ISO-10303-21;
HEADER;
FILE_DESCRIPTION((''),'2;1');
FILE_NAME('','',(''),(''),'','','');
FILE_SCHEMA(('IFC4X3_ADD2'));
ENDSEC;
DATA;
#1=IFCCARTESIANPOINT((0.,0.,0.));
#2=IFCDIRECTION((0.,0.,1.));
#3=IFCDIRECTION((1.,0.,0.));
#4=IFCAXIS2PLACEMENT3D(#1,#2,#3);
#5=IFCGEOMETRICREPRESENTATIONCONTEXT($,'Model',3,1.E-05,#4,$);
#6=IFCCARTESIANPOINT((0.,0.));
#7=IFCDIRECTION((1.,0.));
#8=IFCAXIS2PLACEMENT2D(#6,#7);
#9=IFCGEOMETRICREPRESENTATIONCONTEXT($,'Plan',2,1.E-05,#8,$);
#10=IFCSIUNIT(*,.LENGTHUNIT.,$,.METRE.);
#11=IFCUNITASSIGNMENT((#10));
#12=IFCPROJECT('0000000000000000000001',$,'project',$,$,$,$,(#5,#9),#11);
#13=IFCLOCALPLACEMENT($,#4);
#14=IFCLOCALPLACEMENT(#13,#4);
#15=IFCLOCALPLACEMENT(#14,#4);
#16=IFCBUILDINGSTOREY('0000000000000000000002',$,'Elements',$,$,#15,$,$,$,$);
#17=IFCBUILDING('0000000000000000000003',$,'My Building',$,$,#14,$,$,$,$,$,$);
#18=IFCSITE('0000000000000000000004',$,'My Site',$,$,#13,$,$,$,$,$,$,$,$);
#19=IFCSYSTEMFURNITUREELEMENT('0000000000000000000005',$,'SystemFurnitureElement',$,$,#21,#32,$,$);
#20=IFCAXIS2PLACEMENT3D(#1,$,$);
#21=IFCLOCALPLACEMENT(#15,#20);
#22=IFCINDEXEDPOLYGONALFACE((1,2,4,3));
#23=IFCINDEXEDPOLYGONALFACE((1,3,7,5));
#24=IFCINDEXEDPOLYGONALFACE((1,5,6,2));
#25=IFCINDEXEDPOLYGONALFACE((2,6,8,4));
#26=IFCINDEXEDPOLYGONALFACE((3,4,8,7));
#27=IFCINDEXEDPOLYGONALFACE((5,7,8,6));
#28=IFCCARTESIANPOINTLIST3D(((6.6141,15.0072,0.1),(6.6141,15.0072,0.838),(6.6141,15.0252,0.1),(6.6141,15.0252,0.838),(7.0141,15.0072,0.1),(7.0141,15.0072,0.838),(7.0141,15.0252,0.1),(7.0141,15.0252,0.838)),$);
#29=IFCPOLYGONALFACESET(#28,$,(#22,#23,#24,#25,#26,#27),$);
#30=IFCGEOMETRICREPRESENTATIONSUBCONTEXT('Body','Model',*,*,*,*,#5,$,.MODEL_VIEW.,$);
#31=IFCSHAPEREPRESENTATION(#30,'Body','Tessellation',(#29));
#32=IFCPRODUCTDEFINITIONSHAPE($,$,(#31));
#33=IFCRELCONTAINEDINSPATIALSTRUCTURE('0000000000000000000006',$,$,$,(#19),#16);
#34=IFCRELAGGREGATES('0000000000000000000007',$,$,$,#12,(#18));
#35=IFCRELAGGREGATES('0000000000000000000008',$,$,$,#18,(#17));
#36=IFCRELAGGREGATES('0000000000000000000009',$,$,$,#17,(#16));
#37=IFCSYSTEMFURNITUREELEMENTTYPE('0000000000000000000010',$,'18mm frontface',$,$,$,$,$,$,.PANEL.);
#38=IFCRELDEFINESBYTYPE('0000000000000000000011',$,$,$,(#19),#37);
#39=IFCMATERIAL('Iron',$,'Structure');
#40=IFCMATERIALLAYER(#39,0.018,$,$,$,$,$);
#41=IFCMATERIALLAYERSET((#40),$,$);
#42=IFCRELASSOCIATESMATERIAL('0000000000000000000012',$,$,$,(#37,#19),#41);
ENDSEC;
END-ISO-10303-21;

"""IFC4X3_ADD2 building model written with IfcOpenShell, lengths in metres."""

from ifc_helpers import new_model, si_unit, frame, origin_with_axes, origin_2d_with_axis, place, context, subcontext, project, spatial, line, indexed_curve, outline, extrude, material, layer, layer_set, layer_usage, type_object, element, save


model = new_model("IFC4X3_ADD2")

# Units and contexts
model_context = context("Model", 3, precision=1e-05, world=origin_with_axes())
plan_context = context("Plan", 2, precision=1e-05, world=origin_2d_with_axis())
body_context = subcontext(model_context, "Body", "Model", "MODEL_VIEW")
ifc_project = project(units=[si_unit("LENGTHUNIT", "METRE")], contexts=[model_context, plan_context])

# Site, building, storey
site_placement = place(None, origin_with_axes())
site = spatial("IfcSite", under=ifc_project, at=site_placement, Name="My Site")
building_placement = place(site_placement, origin_with_axes())
building = spatial("IfcBuilding", under=site, at=building_placement, Name="My Building")
storey_placement = place(building_placement, origin_with_axes())
storey = spatial("IfcBuildingStorey", under=building, at=storey_placement, Name="Elements")

# System furniture element
ifc_material_1 = material(Name="Iron", Category="Structure")
ifc_layer_1 = layer(ifc_material_1, 0.018)
ifc_layer_set_1 = layer_set([ifc_layer_1])
ifc_layer_usage_1 = layer_usage(ifc_layer_set_1, "AXIS2", "POSITIVE", 0.0)
system_furniture_element_type_1 = type_object("IfcSystemFurnitureElementType", Name="18mm frontface", PredefinedType="PANEL", material=ifc_layer_set_1)
system_furniture_element_1_placement = place(storey_placement, frame((7.0141, 15.0252, 0.1), z_axis=(0.0, 0.0, 1.0), x_axis=(-1.0, 0.0, 0.0)))
element("IfcSystemFurnitureElement", 1, at=system_furniture_element_1_placement, inside=storey, type_object=system_furniture_element_type_1, material=ifc_layer_usage_1, Name="SystemFurnitureElement", context=body_context, shape_type="SweptSolid", body=[
    extrude(outline(indexed_curve([(0.0, 0.0), (0.0, 0.018), (0.4, 0.018), (0.4, 0.0)], segments=[line(1, 2, 3, 4, 1)])), origin_with_axes(), (0.0, 0.0, 1.0), 0.738),
])

save(model, "model.ifc")
